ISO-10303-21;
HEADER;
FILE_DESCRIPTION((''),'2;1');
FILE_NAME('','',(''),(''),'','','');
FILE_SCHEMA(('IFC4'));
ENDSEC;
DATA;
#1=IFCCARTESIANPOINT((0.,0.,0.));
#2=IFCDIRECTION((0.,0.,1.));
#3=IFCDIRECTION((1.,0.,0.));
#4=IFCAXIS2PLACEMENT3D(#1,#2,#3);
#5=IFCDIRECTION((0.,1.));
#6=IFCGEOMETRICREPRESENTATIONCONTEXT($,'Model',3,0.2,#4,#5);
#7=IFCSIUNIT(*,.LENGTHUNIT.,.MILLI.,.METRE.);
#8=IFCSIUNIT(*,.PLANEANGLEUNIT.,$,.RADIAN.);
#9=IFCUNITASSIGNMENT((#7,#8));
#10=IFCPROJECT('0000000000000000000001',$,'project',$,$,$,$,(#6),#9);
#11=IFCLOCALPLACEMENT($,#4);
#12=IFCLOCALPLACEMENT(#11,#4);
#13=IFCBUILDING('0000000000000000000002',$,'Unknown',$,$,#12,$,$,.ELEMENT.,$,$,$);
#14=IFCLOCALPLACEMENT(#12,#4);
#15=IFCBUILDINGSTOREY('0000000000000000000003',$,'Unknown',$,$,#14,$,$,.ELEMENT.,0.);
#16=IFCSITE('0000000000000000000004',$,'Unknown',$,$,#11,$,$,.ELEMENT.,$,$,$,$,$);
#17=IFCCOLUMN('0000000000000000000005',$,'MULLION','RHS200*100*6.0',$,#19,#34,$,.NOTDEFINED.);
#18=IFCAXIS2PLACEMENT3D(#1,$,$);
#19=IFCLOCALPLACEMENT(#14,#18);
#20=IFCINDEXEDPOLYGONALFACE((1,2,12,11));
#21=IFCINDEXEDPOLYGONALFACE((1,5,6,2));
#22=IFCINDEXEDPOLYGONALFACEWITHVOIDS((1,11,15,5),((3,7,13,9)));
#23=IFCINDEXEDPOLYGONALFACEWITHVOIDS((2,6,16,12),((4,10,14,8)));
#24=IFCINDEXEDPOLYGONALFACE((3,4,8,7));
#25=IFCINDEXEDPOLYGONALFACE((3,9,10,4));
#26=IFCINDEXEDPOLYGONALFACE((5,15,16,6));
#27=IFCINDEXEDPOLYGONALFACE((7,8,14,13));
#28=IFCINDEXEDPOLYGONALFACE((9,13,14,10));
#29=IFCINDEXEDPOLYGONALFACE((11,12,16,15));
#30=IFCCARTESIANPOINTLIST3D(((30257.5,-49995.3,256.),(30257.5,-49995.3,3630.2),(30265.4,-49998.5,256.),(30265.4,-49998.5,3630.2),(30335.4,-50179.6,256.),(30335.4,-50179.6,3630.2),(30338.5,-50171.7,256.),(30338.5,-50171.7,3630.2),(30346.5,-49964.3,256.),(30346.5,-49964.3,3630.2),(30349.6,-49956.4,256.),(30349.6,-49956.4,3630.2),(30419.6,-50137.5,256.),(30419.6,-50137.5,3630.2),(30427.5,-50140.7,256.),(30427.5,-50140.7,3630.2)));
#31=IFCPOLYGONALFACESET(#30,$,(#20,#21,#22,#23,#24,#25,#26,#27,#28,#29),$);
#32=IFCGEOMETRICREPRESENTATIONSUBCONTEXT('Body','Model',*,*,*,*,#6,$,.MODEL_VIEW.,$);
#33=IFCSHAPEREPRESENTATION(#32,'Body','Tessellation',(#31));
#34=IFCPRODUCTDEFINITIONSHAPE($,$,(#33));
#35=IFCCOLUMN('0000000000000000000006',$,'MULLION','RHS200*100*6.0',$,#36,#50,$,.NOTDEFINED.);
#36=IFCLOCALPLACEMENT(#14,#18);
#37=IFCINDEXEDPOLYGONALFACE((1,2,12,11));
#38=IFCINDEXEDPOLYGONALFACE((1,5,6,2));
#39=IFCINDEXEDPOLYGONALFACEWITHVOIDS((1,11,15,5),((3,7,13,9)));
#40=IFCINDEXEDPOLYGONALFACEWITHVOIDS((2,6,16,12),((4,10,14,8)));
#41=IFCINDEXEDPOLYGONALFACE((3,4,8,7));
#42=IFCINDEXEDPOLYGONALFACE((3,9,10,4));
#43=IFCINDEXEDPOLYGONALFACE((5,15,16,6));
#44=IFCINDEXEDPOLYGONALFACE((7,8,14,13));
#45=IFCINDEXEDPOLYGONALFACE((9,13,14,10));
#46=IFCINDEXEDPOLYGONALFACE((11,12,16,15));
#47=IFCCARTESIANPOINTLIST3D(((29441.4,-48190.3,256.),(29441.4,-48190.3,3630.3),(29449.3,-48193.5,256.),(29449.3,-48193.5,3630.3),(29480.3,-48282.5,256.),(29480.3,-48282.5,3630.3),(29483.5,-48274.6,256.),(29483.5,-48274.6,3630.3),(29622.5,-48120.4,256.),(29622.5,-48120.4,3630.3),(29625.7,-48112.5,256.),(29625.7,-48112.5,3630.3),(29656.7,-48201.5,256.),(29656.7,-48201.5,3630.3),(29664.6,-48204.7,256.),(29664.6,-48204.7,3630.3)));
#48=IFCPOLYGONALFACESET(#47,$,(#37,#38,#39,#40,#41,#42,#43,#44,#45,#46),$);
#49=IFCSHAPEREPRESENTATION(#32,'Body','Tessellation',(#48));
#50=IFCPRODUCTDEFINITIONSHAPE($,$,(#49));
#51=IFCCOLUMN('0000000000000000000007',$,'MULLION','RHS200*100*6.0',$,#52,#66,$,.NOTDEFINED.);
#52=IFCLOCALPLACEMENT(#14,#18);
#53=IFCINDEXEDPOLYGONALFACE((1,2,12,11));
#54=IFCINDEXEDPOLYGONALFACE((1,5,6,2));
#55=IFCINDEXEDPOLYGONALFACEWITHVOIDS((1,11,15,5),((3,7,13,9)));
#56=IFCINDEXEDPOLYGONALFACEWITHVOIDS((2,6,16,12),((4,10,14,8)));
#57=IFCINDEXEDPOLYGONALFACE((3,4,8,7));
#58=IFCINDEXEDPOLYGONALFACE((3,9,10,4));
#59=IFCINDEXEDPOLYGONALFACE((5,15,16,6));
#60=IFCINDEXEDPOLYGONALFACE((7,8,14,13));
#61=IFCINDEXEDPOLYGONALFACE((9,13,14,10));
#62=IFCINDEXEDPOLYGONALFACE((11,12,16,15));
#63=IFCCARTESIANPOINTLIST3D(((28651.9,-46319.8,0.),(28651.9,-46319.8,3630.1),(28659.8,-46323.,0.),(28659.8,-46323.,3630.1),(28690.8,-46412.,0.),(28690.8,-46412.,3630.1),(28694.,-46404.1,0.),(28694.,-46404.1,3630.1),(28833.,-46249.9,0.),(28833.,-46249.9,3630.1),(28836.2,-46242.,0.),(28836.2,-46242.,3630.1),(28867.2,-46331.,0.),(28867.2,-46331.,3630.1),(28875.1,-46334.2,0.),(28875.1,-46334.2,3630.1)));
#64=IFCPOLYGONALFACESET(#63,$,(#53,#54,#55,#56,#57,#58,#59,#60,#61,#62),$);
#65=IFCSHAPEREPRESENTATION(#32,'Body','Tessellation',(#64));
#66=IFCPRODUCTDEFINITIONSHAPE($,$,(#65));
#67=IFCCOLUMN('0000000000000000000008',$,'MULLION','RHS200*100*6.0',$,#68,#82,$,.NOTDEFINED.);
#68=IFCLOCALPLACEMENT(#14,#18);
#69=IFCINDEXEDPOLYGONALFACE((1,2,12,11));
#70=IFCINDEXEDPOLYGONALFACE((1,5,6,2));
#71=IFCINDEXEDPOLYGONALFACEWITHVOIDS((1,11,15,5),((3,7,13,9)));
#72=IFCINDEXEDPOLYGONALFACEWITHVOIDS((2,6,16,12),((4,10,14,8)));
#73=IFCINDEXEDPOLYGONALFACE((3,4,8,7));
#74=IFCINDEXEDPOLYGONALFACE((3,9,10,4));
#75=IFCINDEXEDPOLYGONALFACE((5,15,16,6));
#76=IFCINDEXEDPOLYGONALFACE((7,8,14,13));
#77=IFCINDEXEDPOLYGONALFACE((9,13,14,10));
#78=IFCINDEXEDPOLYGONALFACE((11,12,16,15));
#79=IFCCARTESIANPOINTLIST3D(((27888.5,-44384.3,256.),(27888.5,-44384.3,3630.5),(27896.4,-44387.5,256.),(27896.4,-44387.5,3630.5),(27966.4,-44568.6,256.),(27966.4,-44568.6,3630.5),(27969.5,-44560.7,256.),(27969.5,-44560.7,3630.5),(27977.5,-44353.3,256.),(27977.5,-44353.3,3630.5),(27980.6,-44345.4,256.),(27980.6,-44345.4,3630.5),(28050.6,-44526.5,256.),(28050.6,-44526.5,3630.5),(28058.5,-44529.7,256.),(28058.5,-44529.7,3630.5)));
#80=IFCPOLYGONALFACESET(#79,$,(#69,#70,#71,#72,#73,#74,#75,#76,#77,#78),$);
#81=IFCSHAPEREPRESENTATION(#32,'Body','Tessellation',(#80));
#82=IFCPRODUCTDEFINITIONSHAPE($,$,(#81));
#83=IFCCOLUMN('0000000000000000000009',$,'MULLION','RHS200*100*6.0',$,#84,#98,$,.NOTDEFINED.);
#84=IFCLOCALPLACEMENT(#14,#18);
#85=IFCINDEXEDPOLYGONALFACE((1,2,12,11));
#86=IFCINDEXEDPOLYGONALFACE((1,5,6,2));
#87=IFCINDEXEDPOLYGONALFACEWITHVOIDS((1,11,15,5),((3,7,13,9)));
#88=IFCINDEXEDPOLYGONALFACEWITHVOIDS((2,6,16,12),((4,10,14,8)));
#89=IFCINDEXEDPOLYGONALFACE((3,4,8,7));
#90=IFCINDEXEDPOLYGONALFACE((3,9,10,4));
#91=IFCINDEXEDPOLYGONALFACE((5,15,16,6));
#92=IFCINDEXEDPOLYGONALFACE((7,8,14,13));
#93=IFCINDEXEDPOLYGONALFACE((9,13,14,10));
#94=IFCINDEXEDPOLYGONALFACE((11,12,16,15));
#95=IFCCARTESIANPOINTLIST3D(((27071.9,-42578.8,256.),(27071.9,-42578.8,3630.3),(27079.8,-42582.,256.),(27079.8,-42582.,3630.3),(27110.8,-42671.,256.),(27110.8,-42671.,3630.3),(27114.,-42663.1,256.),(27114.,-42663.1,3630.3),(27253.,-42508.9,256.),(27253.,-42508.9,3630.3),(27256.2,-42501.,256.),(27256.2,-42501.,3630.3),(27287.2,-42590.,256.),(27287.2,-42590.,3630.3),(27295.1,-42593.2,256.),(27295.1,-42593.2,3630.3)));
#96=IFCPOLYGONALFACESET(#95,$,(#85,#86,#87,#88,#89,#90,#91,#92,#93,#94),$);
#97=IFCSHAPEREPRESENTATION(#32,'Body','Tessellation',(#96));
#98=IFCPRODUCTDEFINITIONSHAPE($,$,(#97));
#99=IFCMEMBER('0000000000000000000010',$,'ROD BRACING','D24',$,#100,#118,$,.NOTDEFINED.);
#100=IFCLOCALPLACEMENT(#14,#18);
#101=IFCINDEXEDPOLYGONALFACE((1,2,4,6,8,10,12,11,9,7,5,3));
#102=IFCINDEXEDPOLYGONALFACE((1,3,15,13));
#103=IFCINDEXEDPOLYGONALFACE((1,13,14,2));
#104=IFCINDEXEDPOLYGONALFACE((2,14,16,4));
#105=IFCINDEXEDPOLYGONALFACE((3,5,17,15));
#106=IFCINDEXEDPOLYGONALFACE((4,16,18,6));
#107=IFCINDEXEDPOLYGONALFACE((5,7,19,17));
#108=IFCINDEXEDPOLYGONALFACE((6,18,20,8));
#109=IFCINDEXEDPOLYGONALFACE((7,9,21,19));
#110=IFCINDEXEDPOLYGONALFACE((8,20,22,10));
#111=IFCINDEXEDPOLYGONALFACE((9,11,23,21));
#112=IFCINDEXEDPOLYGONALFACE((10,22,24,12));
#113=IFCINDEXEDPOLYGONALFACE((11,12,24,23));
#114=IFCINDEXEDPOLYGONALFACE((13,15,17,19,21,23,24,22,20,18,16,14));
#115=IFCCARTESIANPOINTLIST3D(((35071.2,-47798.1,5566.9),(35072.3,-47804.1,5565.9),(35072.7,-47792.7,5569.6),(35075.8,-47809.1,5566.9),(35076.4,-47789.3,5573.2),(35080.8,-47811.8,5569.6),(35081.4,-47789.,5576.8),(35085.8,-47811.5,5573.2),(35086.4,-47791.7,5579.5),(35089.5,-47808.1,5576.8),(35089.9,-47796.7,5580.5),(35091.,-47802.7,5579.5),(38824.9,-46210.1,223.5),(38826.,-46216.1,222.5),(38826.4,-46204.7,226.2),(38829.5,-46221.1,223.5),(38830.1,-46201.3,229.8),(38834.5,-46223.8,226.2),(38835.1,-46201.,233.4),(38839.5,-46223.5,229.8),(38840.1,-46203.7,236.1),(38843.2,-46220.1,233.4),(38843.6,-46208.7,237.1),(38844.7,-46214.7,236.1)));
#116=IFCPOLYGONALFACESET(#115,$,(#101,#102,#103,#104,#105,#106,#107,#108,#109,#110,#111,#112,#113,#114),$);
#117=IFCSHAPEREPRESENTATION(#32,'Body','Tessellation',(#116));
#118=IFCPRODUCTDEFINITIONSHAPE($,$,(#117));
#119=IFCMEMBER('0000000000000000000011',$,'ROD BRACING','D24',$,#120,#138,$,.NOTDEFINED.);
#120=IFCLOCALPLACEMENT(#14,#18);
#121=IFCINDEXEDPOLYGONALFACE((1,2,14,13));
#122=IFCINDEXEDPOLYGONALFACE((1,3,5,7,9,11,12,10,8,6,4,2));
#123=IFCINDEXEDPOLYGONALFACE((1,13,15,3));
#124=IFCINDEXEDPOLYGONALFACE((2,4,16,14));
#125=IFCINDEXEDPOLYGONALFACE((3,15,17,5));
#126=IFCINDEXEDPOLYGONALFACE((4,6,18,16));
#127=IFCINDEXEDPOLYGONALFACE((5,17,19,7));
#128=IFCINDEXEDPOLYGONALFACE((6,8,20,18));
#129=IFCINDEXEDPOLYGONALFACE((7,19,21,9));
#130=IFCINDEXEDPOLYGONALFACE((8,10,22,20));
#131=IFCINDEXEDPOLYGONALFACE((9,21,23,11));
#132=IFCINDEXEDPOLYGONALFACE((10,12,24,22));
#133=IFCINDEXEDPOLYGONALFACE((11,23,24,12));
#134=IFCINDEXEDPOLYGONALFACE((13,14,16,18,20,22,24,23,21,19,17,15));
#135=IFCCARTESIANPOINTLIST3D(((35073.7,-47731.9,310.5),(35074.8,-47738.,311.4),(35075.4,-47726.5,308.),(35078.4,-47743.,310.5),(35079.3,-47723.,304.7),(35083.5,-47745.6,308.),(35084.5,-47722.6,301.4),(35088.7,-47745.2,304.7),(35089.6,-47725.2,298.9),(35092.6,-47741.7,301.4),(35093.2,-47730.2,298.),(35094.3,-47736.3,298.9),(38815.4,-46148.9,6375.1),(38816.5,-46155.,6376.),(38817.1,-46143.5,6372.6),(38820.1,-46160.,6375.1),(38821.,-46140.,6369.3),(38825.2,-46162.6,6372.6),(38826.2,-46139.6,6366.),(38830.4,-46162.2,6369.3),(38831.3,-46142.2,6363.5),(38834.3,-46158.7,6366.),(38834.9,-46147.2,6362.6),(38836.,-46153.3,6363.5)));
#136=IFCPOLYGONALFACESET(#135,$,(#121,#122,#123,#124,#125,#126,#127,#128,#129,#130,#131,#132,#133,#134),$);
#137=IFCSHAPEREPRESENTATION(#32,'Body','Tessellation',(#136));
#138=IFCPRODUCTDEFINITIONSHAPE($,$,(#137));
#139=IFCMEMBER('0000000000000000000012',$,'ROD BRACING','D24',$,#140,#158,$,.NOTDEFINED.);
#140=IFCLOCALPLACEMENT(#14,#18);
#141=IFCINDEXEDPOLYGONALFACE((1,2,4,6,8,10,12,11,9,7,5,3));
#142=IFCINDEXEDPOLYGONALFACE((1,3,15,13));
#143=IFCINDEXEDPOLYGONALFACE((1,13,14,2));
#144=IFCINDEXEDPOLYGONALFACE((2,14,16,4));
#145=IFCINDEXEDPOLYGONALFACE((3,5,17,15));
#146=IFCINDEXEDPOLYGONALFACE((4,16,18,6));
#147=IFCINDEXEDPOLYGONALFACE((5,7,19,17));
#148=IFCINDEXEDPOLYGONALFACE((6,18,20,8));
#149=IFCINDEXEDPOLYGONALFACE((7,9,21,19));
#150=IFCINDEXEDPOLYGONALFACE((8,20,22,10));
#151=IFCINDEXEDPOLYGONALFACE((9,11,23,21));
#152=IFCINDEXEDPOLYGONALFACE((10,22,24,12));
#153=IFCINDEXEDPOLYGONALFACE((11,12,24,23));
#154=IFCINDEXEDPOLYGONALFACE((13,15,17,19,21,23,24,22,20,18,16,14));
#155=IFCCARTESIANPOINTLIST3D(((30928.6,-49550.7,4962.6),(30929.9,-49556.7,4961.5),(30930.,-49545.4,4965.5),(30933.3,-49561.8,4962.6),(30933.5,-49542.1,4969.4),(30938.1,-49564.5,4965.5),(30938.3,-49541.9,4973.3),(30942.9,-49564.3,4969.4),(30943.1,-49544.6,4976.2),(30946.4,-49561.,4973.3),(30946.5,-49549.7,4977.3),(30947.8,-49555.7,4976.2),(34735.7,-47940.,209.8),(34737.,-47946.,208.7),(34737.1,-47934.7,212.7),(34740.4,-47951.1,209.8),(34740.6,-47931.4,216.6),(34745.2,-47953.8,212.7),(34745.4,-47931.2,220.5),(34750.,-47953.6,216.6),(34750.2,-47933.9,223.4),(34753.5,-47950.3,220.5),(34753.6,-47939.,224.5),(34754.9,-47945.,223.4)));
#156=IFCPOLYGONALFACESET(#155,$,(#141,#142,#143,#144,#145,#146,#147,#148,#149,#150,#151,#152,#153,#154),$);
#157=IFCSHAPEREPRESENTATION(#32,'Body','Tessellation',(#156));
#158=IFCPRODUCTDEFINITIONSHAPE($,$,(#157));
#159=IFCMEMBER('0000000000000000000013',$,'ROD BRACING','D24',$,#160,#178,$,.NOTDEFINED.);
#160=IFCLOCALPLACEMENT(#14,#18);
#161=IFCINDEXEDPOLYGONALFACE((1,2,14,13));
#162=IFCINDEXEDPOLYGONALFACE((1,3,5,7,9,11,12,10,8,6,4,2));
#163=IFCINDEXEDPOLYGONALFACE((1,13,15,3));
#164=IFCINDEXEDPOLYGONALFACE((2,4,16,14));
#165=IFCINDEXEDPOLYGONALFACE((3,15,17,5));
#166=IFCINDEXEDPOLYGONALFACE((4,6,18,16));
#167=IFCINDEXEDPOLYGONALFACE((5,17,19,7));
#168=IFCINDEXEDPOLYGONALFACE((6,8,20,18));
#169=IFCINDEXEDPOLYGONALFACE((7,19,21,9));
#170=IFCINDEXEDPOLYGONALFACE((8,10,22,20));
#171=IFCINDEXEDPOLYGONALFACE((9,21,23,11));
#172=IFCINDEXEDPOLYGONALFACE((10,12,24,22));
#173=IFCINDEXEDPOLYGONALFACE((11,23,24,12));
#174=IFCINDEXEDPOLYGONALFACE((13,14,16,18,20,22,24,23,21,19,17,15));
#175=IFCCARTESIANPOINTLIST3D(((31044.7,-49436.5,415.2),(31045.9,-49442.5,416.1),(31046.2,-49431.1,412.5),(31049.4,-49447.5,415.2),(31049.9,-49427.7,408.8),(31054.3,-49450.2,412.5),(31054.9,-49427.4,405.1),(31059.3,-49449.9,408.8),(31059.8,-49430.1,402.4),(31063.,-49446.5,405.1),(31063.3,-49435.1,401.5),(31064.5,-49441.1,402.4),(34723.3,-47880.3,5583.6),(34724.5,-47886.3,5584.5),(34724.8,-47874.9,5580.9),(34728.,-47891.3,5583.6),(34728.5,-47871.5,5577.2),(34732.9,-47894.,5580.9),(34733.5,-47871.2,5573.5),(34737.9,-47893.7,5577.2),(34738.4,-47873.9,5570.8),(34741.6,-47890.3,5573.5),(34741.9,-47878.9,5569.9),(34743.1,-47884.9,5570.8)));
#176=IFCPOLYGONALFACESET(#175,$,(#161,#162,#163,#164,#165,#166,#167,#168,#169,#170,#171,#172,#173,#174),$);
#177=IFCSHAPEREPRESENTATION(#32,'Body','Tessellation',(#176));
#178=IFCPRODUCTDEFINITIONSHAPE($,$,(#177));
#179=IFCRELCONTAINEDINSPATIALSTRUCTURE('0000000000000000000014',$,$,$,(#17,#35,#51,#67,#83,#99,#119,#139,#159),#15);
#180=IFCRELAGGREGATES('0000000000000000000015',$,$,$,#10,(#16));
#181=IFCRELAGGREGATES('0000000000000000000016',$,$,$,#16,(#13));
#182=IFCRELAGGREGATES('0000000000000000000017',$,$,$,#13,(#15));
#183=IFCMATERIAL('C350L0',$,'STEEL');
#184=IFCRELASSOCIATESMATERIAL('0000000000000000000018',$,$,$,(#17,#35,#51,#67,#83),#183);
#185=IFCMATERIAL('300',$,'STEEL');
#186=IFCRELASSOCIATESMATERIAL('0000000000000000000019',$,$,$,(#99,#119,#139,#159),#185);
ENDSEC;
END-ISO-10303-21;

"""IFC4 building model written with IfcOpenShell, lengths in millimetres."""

from ifc_helpers import new_model, si_unit, direction, frame, origin_with_axes, place, context, subcontext, project, spatial, line, indexed_curve, outline, extrude, material, element, save


model = new_model("IFC4")

# Units and contexts
model_context = context("Model", 3, precision=0.2, world=origin_with_axes(), true_north=direction((0.0, 1.0)))
body_context = subcontext(model_context, "Body", "Model", "MODEL_VIEW")
ifc_project = project(units=[si_unit("LENGTHUNIT", "METRE", prefix="MILLI"), si_unit("PLANEANGLEUNIT", "RADIAN")], contexts=[model_context])

# Site, building, storey
site_placement = place(None, origin_with_axes())
site = spatial("IfcSite", under=ifc_project, at=site_placement, Name="Unknown", CompositionType="ELEMENT")
building_placement = place(site_placement, origin_with_axes())
building = spatial("IfcBuilding", under=site, at=building_placement, Name="Unknown", CompositionType="ELEMENT")
storey_placement = place(building_placement, origin_with_axes())
storey = spatial("IfcBuildingStorey", under=building, at=storey_placement, Name="Unknown", CompositionType="ELEMENT", Elevation=0.0)

# Columns
ifc_material_1 = material(Name="C350L0", Category="STEEL")
column_1_placement = place(storey_placement, frame((30342.5, -50068.0, 256.0), z_axis=(0.921185, 0.389124, 0.0), x_axis=(0.0, 0.0, 1.0)))
element("IfcColumn", 1, at=column_1_placement, inside=storey, material=ifc_material_1, Name="MULLION", Description="RHS200*100*6.0", PredefinedType="NOTDEFINED", context=body_context, shape_type="SolidModel", body=[
    extrude(outline(indexed_curve([(-50.0, -100.0), (50.0, -100.0), (50.0, 100.0), (-50.0, 100.0)], segments=[line(1, 2, 3, 4, 1)]), holes=[indexed_curve([(-44.0, -94.0), (-44.0, 94.0), (44.0, 94.0), (44.0, -94.0)], segments=[line(1, 2, 3, 4, 1)])]), frame((0.0, 0.0, 0.0), z_axis=(-1.0, 0.0, 0.0), x_axis=(0.0, 0.0, 1.0)), (0.0, 0.0, -1.0), 3374.2),
])
column_2_placement = place(storey_placement, frame((29553.0, -48197.5, 256.0), z_axis=(0.388963, -0.921253, 0.0), x_axis=(0.0, 0.0, 1.0)))
element("IfcColumn", 2, at=column_2_placement, inside=storey, material=ifc_material_1, Name="MULLION", Description="RHS200*100*6.0", PredefinedType="NOTDEFINED", context=body_context, shape_type="SolidModel", body=[
    extrude(outline(indexed_curve([(-50.0, -100.0), (50.0, -100.0), (50.0, 100.0), (-50.0, 100.0)], segments=[line(1, 2, 3, 4, 1)]), holes=[indexed_curve([(-44.0, -94.0), (-44.0, 94.0), (44.0, 94.0), (44.0, -94.0)], segments=[line(1, 2, 3, 4, 1)])]), frame((0.0, 0.0, 0.0), z_axis=(-1.0, 0.0, 0.0), x_axis=(0.0, 0.0, 1.0)), (0.0, 0.0, -1.0), 3374.3),
])
column_3_placement = place(storey_placement, frame((28763.5, -46327.0, 0.0), z_axis=(0.388963, -0.921253, 0.0), x_axis=(0.0, 0.0, 1.0)))
element("IfcColumn", 3, at=column_3_placement, inside=storey, material=ifc_material_1, Name="MULLION", Description="RHS200*100*6.0", PredefinedType="NOTDEFINED", context=body_context, shape_type="SolidModel", body=[
    extrude(outline(indexed_curve([(-50.0, -100.0), (50.0, -100.0), (50.0, 100.0), (-50.0, 100.0)], segments=[line(1, 2, 3, 4, 1)]), holes=[indexed_curve([(-44.0, -94.0), (-44.0, 94.0), (44.0, 94.0), (44.0, -94.0)], segments=[line(1, 2, 3, 4, 1)])]), frame((0.0, 0.0, 0.0), z_axis=(-1.0, 0.0, 0.0), x_axis=(0.0, 0.0, 1.0)), (0.0, 0.0, -1.0), 3630.1),
])
column_4_placement = place(storey_placement, frame((27973.5, -44457.0, 256.0), z_axis=(0.921185, 0.389124, 0.0), x_axis=(0.0, 0.0, 1.0)))
element("IfcColumn", 4, at=column_4_placement, inside=storey, material=ifc_material_1, Name="MULLION", Description="RHS200*100*6.0", PredefinedType="NOTDEFINED", context=body_context, shape_type="SolidModel", body=[
    extrude(outline(indexed_curve([(-50.0, -100.0), (50.0, -100.0), (50.0, 100.0), (-50.0, 100.0)], segments=[line(1, 2, 3, 4, 1)]), holes=[indexed_curve([(-44.0, -94.0), (-44.0, 94.0), (44.0, 94.0), (44.0, -94.0)], segments=[line(1, 2, 3, 4, 1)])]), frame((0.0, 0.0, 0.0), z_axis=(-1.0, 0.0, 0.0), x_axis=(0.0, 0.0, 1.0)), (0.0, 0.0, -1.0), 3374.5),
])
column_5_placement = place(storey_placement, frame((27183.5, -42586.0, 256.0), z_axis=(0.388963, -0.921253, 0.0), x_axis=(0.0, 0.0, 1.0)))
element("IfcColumn", 5, at=column_5_placement, inside=storey, material=ifc_material_1, Name="MULLION", Description="RHS200*100*6.0", PredefinedType="NOTDEFINED", context=body_context, shape_type="SolidModel", body=[
    extrude(outline(indexed_curve([(-50.0, -100.0), (50.0, -100.0), (50.0, 100.0), (-50.0, 100.0)], segments=[line(1, 2, 3, 4, 1)]), holes=[indexed_curve([(-44.0, -94.0), (-44.0, 94.0), (44.0, 94.0), (44.0, -94.0)], segments=[line(1, 2, 3, 4, 1)])]), frame((0.0, 0.0, 0.0), z_axis=(-1.0, 0.0, 0.0), x_axis=(0.0, 0.0, 1.0)), (0.0, 0.0, -1.0), 3374.3),
])

# Members
ifc_material_2 = material(Name="300", Category="STEEL")
member_1_placement = place(storey_placement, frame((35081.1, -47800.4, 5573.2), z_axis=(0.732268, 0.309786, 0.606478), x_axis=(0.558552, 0.236295, -0.7951)))
element("IfcMember", 6, at=member_1_placement, inside=storey, material=ifc_material_2, Name="ROD BRACING", Description="D24", PredefinedType="NOTDEFINED", context=body_context, shape_type="SolidModel", body=[
    extrude(outline(indexed_curve([(12.0, 0.0), (10.4, 6.0), (6.0, 10.4), (0.0, 12.0), (-6.0, 10.4), (-10.4, 6.0), (-12.0, 0.0), (-10.4, -6.0), (-6.0, -10.4), (0.0, -12.0), (6.0, -10.4), (10.4, -6.0)], segments=[line(1, 2, 3, 4, 5, 6, 7, 8, 9, 10, 11, 12, 1)])), frame((0.0, 0.0, 0.0), z_axis=(-1.0, 0.0, 0.0), x_axis=(0.0, 0.0, 1.0)), (0.0, 0.0, -1.0), 6720.4),
])
member_2_placement = place(storey_placement, frame((35084.0, -47734.1, 304.7), z_axis=(-0.765143, -0.323709, 0.556569), x_axis=(0.512583, 0.216858, 0.830802)))
element("IfcMember", 7, at=member_2_placement, inside=storey, material=ifc_material_2, Name="ROD BRACING", Description="D24", PredefinedType="NOTDEFINED", context=body_context, shape_type="SolidModel", body=[
    extrude(outline(indexed_curve([(12.0, 0.0), (10.4, 6.0), (6.0, 10.4), (0.0, 12.0), (-6.0, 10.4), (-10.4, 6.0), (-12.0, 0.0), (-10.4, -6.0), (-6.0, -10.4), (0.0, -12.0), (6.0, -10.4), (10.4, -6.0)], segments=[line(1, 2, 3, 4, 5, 6, 7, 8, 9, 10, 11, 12, 1)])), frame((0.0, 0.0, 0.0), z_axis=(-1.0, 0.0, 0.0), x_axis=(0.0, 0.0, 1.0)), (0.0, 0.0, -1.0), 7299.7),
])
member_3_placement = place(storey_placement, frame((30938.2, -49553.2, 4969.4), z_axis=(0.694899, 0.293996, 0.656264), x_axis=(0.604397, 0.255707, -0.754532)))
element("IfcMember", 8, at=member_3_placement, inside=storey, material=ifc_material_2, Name="ROD BRACING", Description="D24", PredefinedType="NOTDEFINED", context=body_context, shape_type="SolidModel", body=[
    extrude(outline(indexed_curve([(12.0, 0.0), (10.4, 6.0), (6.0, 10.4), (0.0, 12.0), (-6.0, 10.4), (-10.4, 6.0), (-12.0, 0.0), (-10.4, -6.0), (-6.0, -10.4), (0.0, -12.0), (6.0, -10.4), (10.4, -6.0)], segments=[line(1, 2, 3, 4, 5, 6, 7, 8, 9, 10, 11, 12, 1)])), frame((0.0, 0.0, 0.0), z_axis=(-1.0, 0.0, 0.0), x_axis=(0.0, 0.0, 1.0)), (0.0, 0.0, -1.0), 6299.0),
])
member_4_placement = place(storey_placement, frame((31054.6, -49438.8, 408.8), z_axis=(-0.728725, -0.308281, 0.611492), x_axis=(0.563171, 0.238245, 0.791251)))
element("IfcMember", 9, at=member_4_placement, inside=storey, material=ifc_material_2, Name="ROD BRACING", Description="D24", PredefinedType="NOTDEFINED", context=body_context, shape_type="SolidModel", body=[
    extrude(outline(indexed_curve([(12.0, 0.0), (10.4, 6.0), (6.0, 10.4), (0.0, 12.0), (-6.0, 10.4), (-10.4, 6.0), (-12.0, 0.0), (-10.4, -6.0), (-6.0, -10.4), (0.0, -12.0), (6.0, -10.4), (10.4, -6.0)], segments=[line(1, 2, 3, 4, 5, 6, 7, 8, 9, 10, 11, 12, 1)])), frame((0.0, 0.0, 0.0), z_axis=(-1.0, 0.0, 0.0), x_axis=(0.0, 0.0, 1.0)), (0.0, 0.0, -1.0), 6531.9),
])

save(model, "model.ifc")
